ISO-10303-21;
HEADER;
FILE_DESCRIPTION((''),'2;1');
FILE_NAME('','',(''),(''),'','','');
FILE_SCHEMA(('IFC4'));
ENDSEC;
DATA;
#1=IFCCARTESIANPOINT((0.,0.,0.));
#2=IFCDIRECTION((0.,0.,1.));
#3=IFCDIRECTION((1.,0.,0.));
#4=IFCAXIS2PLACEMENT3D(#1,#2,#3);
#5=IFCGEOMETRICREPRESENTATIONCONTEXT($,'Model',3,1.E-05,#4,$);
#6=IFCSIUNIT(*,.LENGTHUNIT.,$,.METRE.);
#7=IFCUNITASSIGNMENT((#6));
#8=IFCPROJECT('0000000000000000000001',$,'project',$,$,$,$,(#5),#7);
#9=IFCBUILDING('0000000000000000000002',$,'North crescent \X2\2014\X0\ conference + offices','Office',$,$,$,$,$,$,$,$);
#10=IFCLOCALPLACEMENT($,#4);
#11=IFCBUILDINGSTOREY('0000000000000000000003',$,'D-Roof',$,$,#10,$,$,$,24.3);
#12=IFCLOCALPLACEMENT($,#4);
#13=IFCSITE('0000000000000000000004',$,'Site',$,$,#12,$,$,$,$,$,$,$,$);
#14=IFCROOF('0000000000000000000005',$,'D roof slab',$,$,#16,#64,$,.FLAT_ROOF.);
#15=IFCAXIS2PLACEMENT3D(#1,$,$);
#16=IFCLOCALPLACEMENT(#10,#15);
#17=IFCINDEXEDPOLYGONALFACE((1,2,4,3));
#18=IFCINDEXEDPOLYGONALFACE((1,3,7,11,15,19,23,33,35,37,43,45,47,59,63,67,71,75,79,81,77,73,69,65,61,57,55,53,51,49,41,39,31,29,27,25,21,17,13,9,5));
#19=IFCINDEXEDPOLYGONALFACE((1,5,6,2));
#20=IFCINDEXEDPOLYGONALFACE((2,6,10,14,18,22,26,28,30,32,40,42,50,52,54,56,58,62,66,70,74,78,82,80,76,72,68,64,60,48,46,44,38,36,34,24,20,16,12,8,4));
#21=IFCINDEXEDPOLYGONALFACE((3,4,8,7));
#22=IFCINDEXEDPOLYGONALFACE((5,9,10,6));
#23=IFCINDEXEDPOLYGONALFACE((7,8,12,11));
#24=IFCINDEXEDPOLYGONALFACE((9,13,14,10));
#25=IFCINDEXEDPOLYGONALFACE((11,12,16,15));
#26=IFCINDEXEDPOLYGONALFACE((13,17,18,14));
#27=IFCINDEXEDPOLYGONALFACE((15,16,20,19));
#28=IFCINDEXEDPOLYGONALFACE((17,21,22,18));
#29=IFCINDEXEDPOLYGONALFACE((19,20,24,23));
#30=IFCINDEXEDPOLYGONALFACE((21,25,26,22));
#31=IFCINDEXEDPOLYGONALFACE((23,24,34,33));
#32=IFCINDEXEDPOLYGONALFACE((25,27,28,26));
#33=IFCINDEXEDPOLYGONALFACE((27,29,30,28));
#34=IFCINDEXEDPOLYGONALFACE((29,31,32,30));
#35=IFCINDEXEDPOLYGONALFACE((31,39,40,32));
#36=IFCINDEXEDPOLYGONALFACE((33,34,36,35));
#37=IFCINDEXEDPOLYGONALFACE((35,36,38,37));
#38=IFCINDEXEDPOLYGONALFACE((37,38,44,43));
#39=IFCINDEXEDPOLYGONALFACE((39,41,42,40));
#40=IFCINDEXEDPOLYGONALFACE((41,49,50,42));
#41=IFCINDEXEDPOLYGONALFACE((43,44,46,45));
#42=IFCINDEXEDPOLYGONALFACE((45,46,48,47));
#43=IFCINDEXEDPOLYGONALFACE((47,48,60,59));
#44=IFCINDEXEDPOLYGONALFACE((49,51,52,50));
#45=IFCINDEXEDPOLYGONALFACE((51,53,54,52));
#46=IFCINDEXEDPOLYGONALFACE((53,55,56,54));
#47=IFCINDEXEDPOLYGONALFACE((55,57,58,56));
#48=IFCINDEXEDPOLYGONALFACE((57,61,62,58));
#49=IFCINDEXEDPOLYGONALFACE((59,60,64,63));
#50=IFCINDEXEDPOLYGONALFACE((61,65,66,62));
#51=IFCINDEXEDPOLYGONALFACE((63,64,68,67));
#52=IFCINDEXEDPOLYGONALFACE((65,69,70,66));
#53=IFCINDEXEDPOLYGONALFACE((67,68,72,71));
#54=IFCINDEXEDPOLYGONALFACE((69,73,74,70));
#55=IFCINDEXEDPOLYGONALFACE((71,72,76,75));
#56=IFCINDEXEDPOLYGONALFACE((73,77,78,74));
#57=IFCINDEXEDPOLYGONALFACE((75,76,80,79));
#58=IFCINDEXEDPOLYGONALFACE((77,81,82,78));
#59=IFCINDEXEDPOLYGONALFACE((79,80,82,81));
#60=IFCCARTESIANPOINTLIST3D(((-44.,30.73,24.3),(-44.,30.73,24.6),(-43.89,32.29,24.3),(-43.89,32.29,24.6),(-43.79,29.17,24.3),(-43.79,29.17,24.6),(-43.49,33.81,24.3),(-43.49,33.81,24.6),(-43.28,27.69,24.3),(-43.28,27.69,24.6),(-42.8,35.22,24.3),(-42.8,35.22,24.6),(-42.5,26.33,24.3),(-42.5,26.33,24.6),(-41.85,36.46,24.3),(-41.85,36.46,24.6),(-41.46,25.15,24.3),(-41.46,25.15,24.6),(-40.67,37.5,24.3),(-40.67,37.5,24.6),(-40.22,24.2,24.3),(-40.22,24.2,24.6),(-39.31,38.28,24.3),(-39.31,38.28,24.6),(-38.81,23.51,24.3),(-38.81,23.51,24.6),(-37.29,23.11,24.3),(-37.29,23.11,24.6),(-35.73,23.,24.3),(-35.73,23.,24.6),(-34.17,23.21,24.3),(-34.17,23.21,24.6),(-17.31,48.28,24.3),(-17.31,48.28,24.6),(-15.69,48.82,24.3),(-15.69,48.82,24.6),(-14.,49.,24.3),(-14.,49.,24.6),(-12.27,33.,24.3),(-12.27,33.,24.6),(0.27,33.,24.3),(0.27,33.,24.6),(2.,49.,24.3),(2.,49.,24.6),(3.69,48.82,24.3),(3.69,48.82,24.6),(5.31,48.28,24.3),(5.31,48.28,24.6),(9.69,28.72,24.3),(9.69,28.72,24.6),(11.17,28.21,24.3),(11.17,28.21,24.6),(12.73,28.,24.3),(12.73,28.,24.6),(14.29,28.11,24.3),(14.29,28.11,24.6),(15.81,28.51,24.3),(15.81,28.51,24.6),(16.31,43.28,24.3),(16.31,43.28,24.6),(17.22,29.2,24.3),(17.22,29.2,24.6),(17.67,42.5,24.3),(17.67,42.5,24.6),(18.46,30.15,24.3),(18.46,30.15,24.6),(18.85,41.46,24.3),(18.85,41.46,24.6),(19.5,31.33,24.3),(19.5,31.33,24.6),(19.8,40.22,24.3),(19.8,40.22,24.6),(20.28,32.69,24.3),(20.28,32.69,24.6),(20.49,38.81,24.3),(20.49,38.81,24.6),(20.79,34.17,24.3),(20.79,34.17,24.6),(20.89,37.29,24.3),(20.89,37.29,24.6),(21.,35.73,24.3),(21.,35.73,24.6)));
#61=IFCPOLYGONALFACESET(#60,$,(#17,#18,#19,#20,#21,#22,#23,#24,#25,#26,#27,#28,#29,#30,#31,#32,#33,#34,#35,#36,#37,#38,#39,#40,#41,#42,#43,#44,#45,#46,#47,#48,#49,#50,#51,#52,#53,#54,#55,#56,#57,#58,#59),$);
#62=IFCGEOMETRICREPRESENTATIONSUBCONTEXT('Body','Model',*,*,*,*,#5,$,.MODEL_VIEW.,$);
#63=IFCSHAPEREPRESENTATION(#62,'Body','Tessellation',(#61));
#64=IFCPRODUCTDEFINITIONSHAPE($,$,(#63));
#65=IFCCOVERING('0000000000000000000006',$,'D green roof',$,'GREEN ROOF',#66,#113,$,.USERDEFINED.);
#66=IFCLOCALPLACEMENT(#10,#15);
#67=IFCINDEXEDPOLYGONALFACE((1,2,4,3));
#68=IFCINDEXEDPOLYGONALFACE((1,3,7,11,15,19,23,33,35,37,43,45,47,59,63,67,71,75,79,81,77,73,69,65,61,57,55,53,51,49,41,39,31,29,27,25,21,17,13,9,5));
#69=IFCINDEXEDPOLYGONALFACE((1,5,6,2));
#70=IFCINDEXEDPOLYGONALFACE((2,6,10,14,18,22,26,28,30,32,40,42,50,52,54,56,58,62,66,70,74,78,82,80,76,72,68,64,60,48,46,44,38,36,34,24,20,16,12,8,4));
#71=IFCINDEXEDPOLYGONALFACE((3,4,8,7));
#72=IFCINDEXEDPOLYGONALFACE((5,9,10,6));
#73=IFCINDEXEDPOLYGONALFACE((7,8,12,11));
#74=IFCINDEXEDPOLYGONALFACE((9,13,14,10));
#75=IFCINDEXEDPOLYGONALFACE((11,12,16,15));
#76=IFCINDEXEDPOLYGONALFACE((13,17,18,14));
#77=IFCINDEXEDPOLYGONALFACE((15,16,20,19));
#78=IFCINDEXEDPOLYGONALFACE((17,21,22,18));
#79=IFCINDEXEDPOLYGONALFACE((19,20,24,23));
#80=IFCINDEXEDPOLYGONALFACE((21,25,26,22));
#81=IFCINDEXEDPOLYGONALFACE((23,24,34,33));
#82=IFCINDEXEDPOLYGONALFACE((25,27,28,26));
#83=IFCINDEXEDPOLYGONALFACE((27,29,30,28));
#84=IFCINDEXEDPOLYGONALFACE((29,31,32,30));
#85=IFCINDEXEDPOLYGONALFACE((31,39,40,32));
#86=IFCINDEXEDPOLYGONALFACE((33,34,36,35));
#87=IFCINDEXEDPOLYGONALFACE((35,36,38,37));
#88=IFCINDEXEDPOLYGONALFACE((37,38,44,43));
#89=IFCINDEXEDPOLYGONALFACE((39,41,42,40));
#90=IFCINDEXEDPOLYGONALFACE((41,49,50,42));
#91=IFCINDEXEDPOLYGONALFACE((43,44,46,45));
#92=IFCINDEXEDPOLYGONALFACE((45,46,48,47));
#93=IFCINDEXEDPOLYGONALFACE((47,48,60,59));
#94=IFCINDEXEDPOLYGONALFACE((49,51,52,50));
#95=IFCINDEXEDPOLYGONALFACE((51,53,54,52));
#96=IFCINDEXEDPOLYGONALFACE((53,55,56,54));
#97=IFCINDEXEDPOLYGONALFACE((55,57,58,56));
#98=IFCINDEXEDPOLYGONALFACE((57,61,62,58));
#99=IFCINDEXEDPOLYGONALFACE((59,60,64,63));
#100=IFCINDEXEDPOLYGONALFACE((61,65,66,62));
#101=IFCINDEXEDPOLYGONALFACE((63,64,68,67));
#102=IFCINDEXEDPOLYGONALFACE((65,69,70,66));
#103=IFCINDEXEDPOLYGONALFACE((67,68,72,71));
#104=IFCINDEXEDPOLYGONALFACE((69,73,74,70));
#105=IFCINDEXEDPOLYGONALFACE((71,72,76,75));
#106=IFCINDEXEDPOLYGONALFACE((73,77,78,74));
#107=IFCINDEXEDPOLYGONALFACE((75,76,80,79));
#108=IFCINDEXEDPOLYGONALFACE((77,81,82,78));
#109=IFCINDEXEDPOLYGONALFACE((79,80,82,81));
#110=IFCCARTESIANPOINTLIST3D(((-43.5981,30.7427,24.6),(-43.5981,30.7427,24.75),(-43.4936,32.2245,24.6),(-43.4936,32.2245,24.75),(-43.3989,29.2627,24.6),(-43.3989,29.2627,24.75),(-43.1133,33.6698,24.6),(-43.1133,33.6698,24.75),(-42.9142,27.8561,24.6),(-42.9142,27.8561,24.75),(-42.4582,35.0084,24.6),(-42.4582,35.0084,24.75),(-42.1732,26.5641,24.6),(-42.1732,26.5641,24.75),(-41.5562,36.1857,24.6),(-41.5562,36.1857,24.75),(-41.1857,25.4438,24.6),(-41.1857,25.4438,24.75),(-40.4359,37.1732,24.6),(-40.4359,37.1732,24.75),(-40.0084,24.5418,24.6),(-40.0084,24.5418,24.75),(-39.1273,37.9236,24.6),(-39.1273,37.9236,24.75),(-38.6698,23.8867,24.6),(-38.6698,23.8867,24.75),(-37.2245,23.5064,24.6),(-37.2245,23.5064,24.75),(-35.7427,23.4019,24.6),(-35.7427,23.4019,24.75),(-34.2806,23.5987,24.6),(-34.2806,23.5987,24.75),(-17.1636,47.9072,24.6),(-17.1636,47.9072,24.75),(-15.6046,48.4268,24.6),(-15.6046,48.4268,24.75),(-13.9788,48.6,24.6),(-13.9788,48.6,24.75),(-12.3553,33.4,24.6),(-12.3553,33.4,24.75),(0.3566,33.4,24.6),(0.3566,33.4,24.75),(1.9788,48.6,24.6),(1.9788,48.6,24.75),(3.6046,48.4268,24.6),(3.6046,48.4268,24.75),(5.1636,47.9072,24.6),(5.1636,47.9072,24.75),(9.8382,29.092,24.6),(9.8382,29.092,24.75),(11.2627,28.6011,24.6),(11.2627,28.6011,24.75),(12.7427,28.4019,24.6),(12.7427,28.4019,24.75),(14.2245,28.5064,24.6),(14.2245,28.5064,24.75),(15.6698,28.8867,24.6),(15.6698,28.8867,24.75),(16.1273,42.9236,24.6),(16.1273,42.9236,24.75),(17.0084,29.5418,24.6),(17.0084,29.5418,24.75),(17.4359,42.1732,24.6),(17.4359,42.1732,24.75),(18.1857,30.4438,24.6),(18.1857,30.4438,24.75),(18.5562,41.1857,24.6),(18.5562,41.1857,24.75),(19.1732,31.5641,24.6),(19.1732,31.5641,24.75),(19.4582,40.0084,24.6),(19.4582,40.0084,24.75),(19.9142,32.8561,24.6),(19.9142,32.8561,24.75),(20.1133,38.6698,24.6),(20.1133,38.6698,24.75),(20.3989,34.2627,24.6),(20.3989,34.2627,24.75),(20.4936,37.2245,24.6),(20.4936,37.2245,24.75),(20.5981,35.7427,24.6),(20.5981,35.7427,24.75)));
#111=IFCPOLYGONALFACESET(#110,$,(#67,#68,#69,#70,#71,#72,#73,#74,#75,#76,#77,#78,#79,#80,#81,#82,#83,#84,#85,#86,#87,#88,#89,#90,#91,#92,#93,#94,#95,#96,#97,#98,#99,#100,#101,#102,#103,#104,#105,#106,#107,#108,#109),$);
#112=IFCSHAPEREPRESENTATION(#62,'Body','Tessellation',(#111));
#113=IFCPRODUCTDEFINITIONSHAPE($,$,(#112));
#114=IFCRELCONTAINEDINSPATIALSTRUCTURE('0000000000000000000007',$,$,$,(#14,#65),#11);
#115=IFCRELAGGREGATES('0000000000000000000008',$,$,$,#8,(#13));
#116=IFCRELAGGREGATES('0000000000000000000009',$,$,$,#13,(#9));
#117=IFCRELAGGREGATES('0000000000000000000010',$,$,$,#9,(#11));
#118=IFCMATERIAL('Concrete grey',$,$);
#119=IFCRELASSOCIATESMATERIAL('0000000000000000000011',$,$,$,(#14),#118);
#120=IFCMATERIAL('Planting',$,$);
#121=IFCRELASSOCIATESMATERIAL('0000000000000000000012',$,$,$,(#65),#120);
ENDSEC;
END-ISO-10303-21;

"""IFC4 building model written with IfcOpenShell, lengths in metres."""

from ifc_helpers import new_model, si_unit, frame, origin_with_axes, place, context, subcontext, project, spatial, polyline, outline, extrude, material, element, save


model = new_model("IFC4")

# Units and contexts
model_context = context("Model", 3, precision=1e-05, world=origin_with_axes())
body_context = subcontext(model_context, "Body", "Model", "MODEL_VIEW")
ifc_project = project(units=[si_unit("LENGTHUNIT", "METRE")], contexts=[model_context])

# Site, building, storey
site_placement = place(None, origin_with_axes())
site = spatial("IfcSite", under=ifc_project, at=site_placement, Name="Site")
building = spatial("IfcBuilding", under=site, Name="North crescent — conference + offices", Description="Office")
storey_placement = place(None, origin_with_axes())
storey = spatial("IfcBuildingStorey", under=building, at=storey_placement, Name="D-Roof", Elevation=24.3)

# Roof
ifc_material_1 = material(Name="Concrete grey")
roof_placement = place(storey_placement, origin_with_axes())
element("IfcRoof", 1, at=roof_placement, inside=storey, material=ifc_material_1, Name="D roof slab", PredefinedType="FLAT_ROOF", context=body_context, shape_type="SweptSolid", body=[
    extrude(outline(polyline([(-17.31, 48.28), (-39.31, 38.28), (-40.67, 37.5), (-41.85, 36.46), (-42.8, 35.22), (-43.49, 33.81), (-43.89, 32.29), (-44.0, 30.73), (-43.79, 29.17), (-43.28, 27.69), (-42.5, 26.33), (-41.46, 25.15), (-40.22, 24.2), (-38.81, 23.51), (-37.29, 23.11), (-35.73, 23.0), (-34.17, 23.21), (-12.27, 33.0), (0.27, 33.0), (9.69, 28.72), (11.17, 28.21), (12.73, 28.0), (14.29, 28.11), (15.81, 28.51), (17.22, 29.2), (18.46, 30.15), (19.5, 31.33), (20.28, 32.69), (20.79, 34.17), (21.0, 35.73), (20.89, 37.29), (20.49, 38.81), (19.8, 40.22), (18.85, 41.46), (17.67, 42.5), (16.31, 43.28), (5.31, 48.28), (3.69, 48.82), (2.0, 49.0), (-14.0, 49.0), (-15.69, 48.82), (-17.31, 48.28)])), frame((0.0, 0.0, 24.3), z_axis=(0.0, 0.0, 1.0), x_axis=(1.0, 0.0, 0.0)), (0.0, 0.0, 1.0), 0.3),
])

# Covering
ifc_material_2 = material(Name="Planting")
covering_placement = place(storey_placement, origin_with_axes())
element("IfcCovering", 2, at=covering_placement, inside=storey, material=ifc_material_2, Name="D green roof", ObjectType="GREEN ROOF", PredefinedType="USERDEFINED", context=body_context, shape_type="SweptSolid", body=[
    extrude(outline(polyline([(-17.1636, 47.9072), (-39.1273, 37.9236), (-40.4359, 37.1732), (-41.5562, 36.1857), (-42.4582, 35.0084), (-43.1133, 33.6698), (-43.4936, 32.2245), (-43.5981, 30.7427), (-43.3989, 29.2627), (-42.9142, 27.8561), (-42.1732, 26.5641), (-41.1857, 25.4438), (-40.0084, 24.5418), (-38.6698, 23.8867), (-37.2245, 23.5064), (-35.7427, 23.4019), (-34.2806, 23.5987), (-12.3553, 33.4), (0.3566, 33.4), (9.8382, 29.092), (11.2627, 28.6011), (12.7427, 28.4019), (14.2245, 28.5064), (15.6698, 28.8867), (17.0084, 29.5418), (18.1857, 30.4438), (19.1732, 31.5641), (19.9142, 32.8561), (20.3989, 34.2627), (20.5981, 35.7427), (20.4936, 37.2245), (20.1133, 38.6698), (19.4582, 40.0084), (18.5562, 41.1857), (17.4359, 42.1732), (16.1273, 42.9236), (5.1636, 47.9072), (3.6046, 48.4268), (1.9788, 48.6), (-13.9788, 48.6), (-15.6046, 48.4268), (-17.1636, 47.9072)])), frame((0.0, 0.0, 24.6), z_axis=(0.0, 0.0, 1.0), x_axis=(1.0, 0.0, 0.0)), (0.0, 0.0, 1.0), 0.15),
])

save(model, "model.ifc")
